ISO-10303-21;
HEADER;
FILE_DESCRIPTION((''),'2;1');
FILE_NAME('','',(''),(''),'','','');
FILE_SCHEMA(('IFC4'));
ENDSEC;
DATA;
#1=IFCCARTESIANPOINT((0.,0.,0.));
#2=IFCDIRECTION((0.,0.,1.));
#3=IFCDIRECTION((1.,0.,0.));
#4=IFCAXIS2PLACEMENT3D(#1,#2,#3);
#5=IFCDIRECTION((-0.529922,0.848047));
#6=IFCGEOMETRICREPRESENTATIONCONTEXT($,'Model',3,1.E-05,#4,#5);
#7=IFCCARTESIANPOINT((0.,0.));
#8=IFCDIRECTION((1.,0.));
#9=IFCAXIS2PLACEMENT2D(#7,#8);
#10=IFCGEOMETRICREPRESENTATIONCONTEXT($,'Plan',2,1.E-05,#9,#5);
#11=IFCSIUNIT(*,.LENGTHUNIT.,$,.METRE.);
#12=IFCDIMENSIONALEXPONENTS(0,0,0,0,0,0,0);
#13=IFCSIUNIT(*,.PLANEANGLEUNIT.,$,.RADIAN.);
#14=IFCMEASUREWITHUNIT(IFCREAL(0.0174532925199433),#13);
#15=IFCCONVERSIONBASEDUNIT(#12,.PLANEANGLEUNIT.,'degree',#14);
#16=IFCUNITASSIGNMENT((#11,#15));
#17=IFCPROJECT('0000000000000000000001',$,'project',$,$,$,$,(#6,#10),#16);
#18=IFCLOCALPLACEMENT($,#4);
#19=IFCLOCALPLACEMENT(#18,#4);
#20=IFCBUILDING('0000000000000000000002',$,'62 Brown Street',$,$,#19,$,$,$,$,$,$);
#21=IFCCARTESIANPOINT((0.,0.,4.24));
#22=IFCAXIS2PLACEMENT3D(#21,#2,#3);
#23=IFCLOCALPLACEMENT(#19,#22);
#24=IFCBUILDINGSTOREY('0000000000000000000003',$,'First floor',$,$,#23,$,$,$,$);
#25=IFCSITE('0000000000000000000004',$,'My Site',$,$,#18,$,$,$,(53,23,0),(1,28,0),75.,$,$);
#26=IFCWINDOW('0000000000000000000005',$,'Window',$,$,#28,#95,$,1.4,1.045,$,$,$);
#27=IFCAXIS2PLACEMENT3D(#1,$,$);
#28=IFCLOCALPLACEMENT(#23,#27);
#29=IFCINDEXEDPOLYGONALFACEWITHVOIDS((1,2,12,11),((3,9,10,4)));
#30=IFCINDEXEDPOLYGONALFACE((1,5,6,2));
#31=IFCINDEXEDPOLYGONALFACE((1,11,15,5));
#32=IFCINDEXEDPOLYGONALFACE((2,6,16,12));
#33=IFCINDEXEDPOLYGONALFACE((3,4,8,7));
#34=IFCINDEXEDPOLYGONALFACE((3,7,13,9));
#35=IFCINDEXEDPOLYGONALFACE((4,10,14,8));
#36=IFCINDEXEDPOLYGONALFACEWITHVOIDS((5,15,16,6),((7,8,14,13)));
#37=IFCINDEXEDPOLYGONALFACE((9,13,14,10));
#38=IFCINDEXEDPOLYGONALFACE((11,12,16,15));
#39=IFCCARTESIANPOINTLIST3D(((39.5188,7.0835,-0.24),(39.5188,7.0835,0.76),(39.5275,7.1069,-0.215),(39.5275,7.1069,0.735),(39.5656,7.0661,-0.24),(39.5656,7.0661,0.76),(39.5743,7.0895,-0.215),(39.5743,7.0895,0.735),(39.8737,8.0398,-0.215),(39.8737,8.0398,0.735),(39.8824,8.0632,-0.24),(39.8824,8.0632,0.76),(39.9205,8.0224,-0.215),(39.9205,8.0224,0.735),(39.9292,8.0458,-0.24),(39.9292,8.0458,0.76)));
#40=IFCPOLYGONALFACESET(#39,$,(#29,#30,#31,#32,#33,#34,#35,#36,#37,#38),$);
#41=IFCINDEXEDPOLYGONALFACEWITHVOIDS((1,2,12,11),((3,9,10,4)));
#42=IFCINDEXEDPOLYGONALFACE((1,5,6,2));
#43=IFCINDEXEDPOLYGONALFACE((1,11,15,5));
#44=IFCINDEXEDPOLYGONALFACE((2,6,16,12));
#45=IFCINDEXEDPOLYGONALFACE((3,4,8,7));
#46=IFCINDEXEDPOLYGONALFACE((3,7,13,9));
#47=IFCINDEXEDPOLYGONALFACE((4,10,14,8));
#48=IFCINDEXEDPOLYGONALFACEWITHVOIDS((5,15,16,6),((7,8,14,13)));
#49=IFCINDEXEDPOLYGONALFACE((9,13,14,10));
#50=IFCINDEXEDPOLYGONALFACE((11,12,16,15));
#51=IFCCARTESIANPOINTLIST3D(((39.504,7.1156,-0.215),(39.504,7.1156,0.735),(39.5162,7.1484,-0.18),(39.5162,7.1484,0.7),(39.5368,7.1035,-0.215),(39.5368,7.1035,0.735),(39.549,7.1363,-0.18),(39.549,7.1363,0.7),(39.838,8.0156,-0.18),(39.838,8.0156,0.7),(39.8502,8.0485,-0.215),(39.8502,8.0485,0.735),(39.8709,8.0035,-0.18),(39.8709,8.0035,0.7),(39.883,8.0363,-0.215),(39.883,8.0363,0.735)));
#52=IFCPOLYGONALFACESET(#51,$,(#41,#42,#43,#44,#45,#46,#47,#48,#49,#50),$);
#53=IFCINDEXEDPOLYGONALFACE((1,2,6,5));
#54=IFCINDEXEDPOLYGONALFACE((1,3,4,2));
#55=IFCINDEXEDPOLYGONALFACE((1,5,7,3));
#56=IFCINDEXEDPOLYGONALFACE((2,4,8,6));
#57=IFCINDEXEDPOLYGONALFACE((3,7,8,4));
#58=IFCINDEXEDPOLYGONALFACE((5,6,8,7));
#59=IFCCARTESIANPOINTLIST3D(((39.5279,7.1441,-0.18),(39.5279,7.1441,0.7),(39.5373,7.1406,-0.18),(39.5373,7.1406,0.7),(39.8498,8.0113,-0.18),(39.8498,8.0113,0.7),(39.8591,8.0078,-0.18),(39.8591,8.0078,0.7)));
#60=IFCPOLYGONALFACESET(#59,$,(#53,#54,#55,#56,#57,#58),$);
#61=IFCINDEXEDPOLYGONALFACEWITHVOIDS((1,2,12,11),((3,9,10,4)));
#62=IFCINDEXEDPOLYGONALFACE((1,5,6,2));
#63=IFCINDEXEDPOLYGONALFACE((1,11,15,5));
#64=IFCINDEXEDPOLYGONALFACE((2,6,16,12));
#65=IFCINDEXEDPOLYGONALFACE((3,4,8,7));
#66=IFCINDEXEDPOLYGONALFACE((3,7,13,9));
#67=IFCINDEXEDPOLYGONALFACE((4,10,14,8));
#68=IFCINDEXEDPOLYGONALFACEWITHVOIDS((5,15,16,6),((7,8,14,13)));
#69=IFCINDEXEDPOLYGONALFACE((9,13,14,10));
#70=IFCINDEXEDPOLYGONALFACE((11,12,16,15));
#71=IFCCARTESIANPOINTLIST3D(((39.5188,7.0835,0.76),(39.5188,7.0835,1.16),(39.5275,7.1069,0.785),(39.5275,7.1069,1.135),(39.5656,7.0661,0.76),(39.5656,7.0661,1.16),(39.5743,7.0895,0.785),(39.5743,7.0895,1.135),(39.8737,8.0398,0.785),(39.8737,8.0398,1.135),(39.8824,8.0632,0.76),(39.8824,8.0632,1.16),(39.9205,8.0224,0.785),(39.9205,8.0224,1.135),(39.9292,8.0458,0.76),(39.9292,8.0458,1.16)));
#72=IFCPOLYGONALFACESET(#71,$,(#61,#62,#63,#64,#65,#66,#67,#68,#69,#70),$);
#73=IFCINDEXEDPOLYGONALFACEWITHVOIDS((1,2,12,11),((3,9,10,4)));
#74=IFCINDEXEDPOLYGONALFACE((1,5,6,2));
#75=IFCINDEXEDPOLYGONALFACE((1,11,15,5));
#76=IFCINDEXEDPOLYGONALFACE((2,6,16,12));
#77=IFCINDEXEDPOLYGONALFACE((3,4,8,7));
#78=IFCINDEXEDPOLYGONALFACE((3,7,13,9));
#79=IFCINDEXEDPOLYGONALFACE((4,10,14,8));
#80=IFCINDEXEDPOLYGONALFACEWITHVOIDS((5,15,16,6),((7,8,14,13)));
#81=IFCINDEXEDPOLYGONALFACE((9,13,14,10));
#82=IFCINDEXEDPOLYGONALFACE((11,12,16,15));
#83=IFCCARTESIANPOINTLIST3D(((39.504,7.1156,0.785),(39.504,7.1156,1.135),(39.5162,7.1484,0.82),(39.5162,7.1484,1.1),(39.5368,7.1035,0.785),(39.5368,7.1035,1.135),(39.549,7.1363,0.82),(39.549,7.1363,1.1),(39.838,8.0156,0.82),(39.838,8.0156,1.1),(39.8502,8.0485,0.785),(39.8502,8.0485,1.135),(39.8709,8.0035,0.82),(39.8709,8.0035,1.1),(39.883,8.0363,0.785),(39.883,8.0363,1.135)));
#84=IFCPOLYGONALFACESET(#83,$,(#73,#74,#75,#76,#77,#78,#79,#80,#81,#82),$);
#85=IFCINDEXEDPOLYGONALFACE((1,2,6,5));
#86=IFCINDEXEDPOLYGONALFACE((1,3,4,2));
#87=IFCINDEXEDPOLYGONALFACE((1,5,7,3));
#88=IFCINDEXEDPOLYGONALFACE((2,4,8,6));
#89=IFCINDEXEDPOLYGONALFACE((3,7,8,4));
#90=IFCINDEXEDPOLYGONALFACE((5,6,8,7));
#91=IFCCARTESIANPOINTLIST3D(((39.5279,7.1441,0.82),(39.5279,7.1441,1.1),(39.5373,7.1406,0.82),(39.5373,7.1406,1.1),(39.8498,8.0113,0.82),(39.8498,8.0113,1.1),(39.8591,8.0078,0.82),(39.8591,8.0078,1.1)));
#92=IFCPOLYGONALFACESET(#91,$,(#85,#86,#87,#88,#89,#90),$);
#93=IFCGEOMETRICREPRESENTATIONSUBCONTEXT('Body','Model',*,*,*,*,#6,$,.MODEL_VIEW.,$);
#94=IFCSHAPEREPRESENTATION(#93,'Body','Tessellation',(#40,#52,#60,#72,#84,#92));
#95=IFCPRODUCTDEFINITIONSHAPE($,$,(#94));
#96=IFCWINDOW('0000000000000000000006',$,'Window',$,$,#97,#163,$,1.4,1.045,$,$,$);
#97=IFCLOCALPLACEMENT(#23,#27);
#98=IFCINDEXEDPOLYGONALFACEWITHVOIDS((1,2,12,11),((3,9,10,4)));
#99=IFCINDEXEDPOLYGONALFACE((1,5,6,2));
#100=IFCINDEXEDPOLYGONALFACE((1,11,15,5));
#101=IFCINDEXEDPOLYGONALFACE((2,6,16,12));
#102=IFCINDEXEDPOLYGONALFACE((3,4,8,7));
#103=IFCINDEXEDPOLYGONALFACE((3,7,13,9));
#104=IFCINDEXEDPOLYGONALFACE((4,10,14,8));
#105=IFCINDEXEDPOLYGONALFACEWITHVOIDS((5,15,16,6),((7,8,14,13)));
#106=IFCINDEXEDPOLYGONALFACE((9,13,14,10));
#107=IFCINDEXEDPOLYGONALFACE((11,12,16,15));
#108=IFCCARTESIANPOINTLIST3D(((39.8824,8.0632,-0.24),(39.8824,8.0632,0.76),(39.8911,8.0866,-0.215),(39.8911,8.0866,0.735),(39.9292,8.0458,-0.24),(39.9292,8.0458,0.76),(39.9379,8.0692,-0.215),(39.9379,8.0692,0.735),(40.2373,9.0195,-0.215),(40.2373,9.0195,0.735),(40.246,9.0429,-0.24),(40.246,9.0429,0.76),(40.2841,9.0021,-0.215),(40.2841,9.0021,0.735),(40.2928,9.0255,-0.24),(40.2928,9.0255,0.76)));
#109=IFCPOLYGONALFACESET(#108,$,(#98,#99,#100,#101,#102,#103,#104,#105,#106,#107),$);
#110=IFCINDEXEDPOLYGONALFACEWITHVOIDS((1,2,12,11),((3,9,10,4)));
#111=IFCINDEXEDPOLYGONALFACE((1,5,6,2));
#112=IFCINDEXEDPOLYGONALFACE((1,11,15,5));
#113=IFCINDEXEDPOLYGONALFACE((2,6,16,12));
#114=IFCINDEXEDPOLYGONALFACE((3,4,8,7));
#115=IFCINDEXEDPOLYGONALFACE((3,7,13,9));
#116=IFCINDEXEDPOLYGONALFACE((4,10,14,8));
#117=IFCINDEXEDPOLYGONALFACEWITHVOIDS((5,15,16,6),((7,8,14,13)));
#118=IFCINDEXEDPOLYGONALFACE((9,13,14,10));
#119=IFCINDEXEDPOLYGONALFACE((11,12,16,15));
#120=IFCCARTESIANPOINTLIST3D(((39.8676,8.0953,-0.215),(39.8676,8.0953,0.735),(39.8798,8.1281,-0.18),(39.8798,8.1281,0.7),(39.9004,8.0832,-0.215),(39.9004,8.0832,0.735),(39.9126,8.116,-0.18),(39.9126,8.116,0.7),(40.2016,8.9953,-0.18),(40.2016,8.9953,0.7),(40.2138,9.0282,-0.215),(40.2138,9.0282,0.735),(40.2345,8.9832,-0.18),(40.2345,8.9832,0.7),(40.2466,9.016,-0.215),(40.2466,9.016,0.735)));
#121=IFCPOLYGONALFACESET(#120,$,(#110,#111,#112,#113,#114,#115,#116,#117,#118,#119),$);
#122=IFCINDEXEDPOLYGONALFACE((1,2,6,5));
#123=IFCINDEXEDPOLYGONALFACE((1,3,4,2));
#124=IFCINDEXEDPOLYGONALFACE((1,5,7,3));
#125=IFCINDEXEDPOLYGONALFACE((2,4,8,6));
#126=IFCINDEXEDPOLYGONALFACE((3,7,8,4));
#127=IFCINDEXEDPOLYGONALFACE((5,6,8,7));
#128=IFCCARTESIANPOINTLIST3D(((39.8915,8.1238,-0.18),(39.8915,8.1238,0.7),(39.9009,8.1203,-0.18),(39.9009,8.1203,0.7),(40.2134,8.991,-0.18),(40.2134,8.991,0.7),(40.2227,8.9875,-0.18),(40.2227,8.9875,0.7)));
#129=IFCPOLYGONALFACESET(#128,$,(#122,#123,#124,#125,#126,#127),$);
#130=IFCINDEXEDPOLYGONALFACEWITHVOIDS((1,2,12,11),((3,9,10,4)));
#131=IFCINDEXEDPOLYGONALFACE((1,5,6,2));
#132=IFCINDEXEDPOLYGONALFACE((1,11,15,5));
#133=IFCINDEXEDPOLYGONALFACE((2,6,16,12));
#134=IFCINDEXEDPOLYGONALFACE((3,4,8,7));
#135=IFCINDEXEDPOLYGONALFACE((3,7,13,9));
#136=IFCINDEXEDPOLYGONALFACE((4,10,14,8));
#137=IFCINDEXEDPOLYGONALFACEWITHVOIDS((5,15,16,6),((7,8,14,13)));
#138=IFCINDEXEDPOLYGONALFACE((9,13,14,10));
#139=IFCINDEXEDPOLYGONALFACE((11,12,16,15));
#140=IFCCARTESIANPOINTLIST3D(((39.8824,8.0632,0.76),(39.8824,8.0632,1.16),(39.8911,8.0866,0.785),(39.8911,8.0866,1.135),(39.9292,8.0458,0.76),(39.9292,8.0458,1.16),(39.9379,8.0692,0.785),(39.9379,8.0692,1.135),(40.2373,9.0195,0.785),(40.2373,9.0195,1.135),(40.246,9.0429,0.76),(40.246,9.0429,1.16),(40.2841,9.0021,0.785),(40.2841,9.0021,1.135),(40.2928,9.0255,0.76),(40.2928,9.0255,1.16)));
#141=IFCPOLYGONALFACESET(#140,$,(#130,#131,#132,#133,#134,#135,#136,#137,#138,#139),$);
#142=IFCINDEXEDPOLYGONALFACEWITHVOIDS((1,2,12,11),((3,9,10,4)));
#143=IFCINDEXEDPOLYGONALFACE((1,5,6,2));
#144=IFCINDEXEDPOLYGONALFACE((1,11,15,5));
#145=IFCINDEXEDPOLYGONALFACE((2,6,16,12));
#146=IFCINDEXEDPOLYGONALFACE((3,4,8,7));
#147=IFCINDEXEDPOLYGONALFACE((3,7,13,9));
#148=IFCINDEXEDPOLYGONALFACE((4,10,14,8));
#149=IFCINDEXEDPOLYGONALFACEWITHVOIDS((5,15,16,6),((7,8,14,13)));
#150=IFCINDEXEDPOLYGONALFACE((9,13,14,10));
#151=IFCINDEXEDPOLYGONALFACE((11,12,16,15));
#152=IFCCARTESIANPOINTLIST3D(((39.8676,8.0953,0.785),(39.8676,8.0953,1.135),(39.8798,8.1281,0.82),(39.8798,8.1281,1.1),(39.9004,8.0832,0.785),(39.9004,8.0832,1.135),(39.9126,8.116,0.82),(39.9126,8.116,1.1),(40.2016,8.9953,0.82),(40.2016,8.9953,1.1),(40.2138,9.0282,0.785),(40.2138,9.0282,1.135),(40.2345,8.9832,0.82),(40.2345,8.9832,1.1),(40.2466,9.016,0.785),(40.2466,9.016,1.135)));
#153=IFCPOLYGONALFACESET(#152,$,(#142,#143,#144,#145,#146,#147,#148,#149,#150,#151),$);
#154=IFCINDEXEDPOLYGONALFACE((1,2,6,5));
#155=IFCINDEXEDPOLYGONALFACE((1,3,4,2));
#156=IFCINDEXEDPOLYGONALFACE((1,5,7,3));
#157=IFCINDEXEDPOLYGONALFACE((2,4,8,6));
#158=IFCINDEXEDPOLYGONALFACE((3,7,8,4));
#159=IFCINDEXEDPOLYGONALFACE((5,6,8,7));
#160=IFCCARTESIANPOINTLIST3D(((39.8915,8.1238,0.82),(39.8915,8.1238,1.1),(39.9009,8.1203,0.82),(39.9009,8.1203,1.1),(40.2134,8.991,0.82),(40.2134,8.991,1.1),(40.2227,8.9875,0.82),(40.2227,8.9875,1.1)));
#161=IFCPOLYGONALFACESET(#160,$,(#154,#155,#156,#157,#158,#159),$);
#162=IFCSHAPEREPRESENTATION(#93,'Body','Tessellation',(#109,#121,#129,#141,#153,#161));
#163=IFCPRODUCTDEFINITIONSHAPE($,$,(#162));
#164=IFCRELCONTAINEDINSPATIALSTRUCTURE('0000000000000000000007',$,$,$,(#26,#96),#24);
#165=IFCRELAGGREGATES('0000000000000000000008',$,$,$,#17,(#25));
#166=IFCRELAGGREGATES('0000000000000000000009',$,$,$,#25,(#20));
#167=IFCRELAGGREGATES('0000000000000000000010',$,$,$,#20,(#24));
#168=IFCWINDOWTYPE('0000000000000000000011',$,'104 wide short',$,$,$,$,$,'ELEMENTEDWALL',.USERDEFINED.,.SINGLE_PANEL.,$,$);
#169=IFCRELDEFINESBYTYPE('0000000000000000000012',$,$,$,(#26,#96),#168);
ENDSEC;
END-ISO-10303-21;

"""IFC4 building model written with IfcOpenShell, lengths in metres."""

from ifc_helpers import new_model, entity, si_unit, converted_unit, direction, frame, origin_with_axes, origin_2d_with_axis, place, context, subcontext, project, spatial, line, indexed_curve, outline, extrude, shape, source, transform, mapped, type_object, type_shapes, element, save


model = new_model("IFC4")

# Units and contexts
model_context = context("Model", 3, precision=1e-05, world=origin_with_axes(), true_north=direction((-0.529922, 0.848047)))
plan_context = context("Plan", 2, precision=1e-05, world=origin_2d_with_axis(), true_north=direction((-0.529922, 0.848047)))
body_context_1 = subcontext(model_context, "Body", "Model", "MODEL_VIEW")
body_context_2 = subcontext(plan_context, "Body", "Plan", "PLAN_VIEW")
ifc_project = project(units=[si_unit("LENGTHUNIT", "METRE"), converted_unit("PLANEANGLEUNIT", "degree", entity("IfcReal", 0.0174532925199433), si_unit("PLANEANGLEUNIT", "RADIAN"), dimensions=[0, 0, 0, 0, 0, 0, 0])], contexts=[model_context, plan_context])

# Site, building, storey
site_placement = place(None, origin_with_axes())
site = spatial("IfcSite", under=ifc_project, at=site_placement, Name="My Site", RefLatitude=(53, 23, 0), RefLongitude=(1, 28, 0), RefElevation=75.0)
building_placement = place(site_placement, origin_with_axes())
building = spatial("IfcBuilding", under=site, at=building_placement, Name="62 Brown Street")
storey_placement = place(building_placement, frame((0.0, 0.0, 4.24), z_axis=(0.0, 0.0, 1.0), x_axis=(1.0, 0.0, 0.0)))
storey = spatial("IfcBuildingStorey", under=building, at=storey_placement, Name="First floor")

# Shared definitions
window_type = type_object("IfcWindowType", Name="104 wide short", ElementType="ELEMENTEDWALL", PartitioningType="SINGLE_PANEL", PredefinedType="USERDEFINED")
shared_shape_1 = source(origin_with_axes(), body_context_1, "Body", "SweptSolid", [
    extrude(outline(indexed_curve([(0.0, 0.0), (1.045, 0.0), (1.045, 1.0), (0.0, 1.0)], segments=[line(1, 2, 3, 4, 1)]), holes=[indexed_curve([(0.025, 0.025), (1.02, 0.025), (1.02, 0.975), (0.025, 0.975)], segments=[line(1, 2, 3, 4, 1)])]), frame((0.0, 0.15, 0.0), z_axis=(0.0, -1.0, 0.0), x_axis=(1.0, 0.0, 0.0)), (0.0, 0.0, -1.0), 0.05),
    extrude(outline(indexed_curve([(0.0, 0.0), (0.995, 0.0), (0.995, 0.95), (0.0, 0.95)], segments=[line(1, 2, 3, 4, 1)]), holes=[indexed_curve([(0.035, 0.035), (0.96, 0.035), (0.96, 0.915), (0.035, 0.915)], segments=[line(1, 2, 3, 4, 1)])]), frame((0.025, 0.19, 0.025), z_axis=(0.0, -1.0, 0.0), x_axis=(1.0, 0.0, 0.0)), (0.0, 0.0, -1.0), 0.035),
    extrude(outline(indexed_curve([(0.035, 0.035), (0.96, 0.035), (0.96, 0.915), (0.035, 0.915)], segments=[line(1, 2, 3, 4, 1)])), frame((0.025, 0.2025, 0.025), z_axis=(0.0, -1.0, 0.0), x_axis=(1.0, 0.0, 0.0)), (0.0, 0.0, -1.0), 0.01),
    extrude(outline(indexed_curve([(0.0, 0.0), (1.045, 0.0), (1.045, 0.4), (0.0, 0.4)], segments=[line(1, 2, 3, 4, 1)]), holes=[indexed_curve([(0.025, 0.025), (1.02, 0.025), (1.02, 0.375), (0.025, 0.375)], segments=[line(1, 2, 3, 4, 1)])]), frame((0.0, 0.15, 1.0), z_axis=(0.0, -1.0, 0.0), x_axis=(1.0, 0.0, 0.0)), (0.0, 0.0, -1.0), 0.05),
    extrude(outline(indexed_curve([(0.0, 0.0), (0.995, 0.0), (0.995, 0.35), (0.0, 0.35)], segments=[line(1, 2, 3, 4, 1)]), holes=[indexed_curve([(0.035, 0.035), (0.96, 0.035), (0.96, 0.315), (0.035, 0.315)], segments=[line(1, 2, 3, 4, 1)])]), frame((0.025, 0.19, 1.025), z_axis=(0.0, -1.0, 0.0), x_axis=(1.0, 0.0, 0.0)), (0.0, 0.0, -1.0), 0.035),
    extrude(outline(indexed_curve([(0.035, 0.035), (0.96, 0.035), (0.96, 0.315), (0.035, 0.315)], segments=[line(1, 2, 3, 4, 1)])), frame((0.025, 0.2025, 1.025), z_axis=(0.0, -1.0, 0.0), x_axis=(1.0, 0.0, 0.0)), (0.0, 0.0, -1.0), 0.01),
])
shared_shape_2 = source(origin_with_axes(), body_context_2, "Body", "Curve2D", [
    entity("IfcIndexedPolyCurve", entity("IfcCartesianPointList2D", [[0.025, 0.15], [1.02, 0.15]])),
    entity("IfcIndexedPolyCurve", entity("IfcCartesianPointList2D", [[0.0, 0.2], [0.025, 0.2], [0.025, 0.15], [0.0, 0.15]]), [entity("IfcLineIndex", [1, 2, 3, 4, 1])]),
    entity("IfcIndexedPolyCurve", entity("IfcCartesianPointList2D", [[1.045, 0.2], [1.02, 0.2], [1.02, 0.15], [1.045, 0.15]]), [entity("IfcLineIndex", [1, 2, 3, 4, 1])]),
    entity("IfcIndexedPolyCurve", entity("IfcCartesianPointList2D", [[0.025, 0.19], [0.06, 0.19], [0.06, 0.225], [0.025, 0.225]]), [entity("IfcLineIndex", [1, 2, 3, 4, 1])]),
    entity("IfcIndexedPolyCurve", entity("IfcCartesianPointList2D", [[1.02, 0.19], [0.985, 0.19], [0.985, 0.225], [1.02, 0.225]]), [entity("IfcLineIndex", [1, 2, 3, 4, 1])]),
    entity("IfcIndexedPolyCurve", entity("IfcCartesianPointList2D", [[0.06, 0.19], [0.985, 0.19]])),
    entity("IfcIndexedPolyCurve", entity("IfcCartesianPointList2D", [[0.06, 0.225], [0.985, 0.225]])),
    entity("IfcIndexedPolyCurve", entity("IfcCartesianPointList2D", [[0.06, 0.2075], [0.985, 0.2075]])),
])
type_shapes(window_type, [shared_shape_1, shared_shape_2])

# Windows
for number, where, z_axis, x_axis, name in (
    (1, (39.7063, 7.0139, -0.24), (0.0, 0.0, 1.0), (0.347944, 0.937515, 0.0), "Window"),
    (2, (40.0699, 7.9936, -0.24), (0.0, 0.0, 1.0), (0.347944, 0.937515, 0.0), "Window"),
):
    element("IfcWindow", number, at=place(storey_placement, frame(where, z_axis=z_axis, x_axis=x_axis)), inside=storey, type_object=window_type, Name=name, OverallHeight=1.4, OverallWidth=1.045, shapes=[
        shape(body_context_1, "Body", "MappedRepresentation", [mapped(shared_shape_1, transform((0.0, 0.0, 0.0), x_axis=(1.0, 0.0, 0.0), y_axis=(0.0, 1.0, 0.0), z_axis=(0.0, 0.0, 1.0), scale=1.0))]),
        shape(body_context_2, "Body", "MappedRepresentation", [mapped(shared_shape_2, transform((0.0, 0.0, 0.0), x_axis=(1.0, 0.0, 0.0), y_axis=(0.0, 1.0, 0.0), z_axis=(0.0, 0.0, 1.0), scale=1.0))]),
    ])

save(model, "model.ifc")
